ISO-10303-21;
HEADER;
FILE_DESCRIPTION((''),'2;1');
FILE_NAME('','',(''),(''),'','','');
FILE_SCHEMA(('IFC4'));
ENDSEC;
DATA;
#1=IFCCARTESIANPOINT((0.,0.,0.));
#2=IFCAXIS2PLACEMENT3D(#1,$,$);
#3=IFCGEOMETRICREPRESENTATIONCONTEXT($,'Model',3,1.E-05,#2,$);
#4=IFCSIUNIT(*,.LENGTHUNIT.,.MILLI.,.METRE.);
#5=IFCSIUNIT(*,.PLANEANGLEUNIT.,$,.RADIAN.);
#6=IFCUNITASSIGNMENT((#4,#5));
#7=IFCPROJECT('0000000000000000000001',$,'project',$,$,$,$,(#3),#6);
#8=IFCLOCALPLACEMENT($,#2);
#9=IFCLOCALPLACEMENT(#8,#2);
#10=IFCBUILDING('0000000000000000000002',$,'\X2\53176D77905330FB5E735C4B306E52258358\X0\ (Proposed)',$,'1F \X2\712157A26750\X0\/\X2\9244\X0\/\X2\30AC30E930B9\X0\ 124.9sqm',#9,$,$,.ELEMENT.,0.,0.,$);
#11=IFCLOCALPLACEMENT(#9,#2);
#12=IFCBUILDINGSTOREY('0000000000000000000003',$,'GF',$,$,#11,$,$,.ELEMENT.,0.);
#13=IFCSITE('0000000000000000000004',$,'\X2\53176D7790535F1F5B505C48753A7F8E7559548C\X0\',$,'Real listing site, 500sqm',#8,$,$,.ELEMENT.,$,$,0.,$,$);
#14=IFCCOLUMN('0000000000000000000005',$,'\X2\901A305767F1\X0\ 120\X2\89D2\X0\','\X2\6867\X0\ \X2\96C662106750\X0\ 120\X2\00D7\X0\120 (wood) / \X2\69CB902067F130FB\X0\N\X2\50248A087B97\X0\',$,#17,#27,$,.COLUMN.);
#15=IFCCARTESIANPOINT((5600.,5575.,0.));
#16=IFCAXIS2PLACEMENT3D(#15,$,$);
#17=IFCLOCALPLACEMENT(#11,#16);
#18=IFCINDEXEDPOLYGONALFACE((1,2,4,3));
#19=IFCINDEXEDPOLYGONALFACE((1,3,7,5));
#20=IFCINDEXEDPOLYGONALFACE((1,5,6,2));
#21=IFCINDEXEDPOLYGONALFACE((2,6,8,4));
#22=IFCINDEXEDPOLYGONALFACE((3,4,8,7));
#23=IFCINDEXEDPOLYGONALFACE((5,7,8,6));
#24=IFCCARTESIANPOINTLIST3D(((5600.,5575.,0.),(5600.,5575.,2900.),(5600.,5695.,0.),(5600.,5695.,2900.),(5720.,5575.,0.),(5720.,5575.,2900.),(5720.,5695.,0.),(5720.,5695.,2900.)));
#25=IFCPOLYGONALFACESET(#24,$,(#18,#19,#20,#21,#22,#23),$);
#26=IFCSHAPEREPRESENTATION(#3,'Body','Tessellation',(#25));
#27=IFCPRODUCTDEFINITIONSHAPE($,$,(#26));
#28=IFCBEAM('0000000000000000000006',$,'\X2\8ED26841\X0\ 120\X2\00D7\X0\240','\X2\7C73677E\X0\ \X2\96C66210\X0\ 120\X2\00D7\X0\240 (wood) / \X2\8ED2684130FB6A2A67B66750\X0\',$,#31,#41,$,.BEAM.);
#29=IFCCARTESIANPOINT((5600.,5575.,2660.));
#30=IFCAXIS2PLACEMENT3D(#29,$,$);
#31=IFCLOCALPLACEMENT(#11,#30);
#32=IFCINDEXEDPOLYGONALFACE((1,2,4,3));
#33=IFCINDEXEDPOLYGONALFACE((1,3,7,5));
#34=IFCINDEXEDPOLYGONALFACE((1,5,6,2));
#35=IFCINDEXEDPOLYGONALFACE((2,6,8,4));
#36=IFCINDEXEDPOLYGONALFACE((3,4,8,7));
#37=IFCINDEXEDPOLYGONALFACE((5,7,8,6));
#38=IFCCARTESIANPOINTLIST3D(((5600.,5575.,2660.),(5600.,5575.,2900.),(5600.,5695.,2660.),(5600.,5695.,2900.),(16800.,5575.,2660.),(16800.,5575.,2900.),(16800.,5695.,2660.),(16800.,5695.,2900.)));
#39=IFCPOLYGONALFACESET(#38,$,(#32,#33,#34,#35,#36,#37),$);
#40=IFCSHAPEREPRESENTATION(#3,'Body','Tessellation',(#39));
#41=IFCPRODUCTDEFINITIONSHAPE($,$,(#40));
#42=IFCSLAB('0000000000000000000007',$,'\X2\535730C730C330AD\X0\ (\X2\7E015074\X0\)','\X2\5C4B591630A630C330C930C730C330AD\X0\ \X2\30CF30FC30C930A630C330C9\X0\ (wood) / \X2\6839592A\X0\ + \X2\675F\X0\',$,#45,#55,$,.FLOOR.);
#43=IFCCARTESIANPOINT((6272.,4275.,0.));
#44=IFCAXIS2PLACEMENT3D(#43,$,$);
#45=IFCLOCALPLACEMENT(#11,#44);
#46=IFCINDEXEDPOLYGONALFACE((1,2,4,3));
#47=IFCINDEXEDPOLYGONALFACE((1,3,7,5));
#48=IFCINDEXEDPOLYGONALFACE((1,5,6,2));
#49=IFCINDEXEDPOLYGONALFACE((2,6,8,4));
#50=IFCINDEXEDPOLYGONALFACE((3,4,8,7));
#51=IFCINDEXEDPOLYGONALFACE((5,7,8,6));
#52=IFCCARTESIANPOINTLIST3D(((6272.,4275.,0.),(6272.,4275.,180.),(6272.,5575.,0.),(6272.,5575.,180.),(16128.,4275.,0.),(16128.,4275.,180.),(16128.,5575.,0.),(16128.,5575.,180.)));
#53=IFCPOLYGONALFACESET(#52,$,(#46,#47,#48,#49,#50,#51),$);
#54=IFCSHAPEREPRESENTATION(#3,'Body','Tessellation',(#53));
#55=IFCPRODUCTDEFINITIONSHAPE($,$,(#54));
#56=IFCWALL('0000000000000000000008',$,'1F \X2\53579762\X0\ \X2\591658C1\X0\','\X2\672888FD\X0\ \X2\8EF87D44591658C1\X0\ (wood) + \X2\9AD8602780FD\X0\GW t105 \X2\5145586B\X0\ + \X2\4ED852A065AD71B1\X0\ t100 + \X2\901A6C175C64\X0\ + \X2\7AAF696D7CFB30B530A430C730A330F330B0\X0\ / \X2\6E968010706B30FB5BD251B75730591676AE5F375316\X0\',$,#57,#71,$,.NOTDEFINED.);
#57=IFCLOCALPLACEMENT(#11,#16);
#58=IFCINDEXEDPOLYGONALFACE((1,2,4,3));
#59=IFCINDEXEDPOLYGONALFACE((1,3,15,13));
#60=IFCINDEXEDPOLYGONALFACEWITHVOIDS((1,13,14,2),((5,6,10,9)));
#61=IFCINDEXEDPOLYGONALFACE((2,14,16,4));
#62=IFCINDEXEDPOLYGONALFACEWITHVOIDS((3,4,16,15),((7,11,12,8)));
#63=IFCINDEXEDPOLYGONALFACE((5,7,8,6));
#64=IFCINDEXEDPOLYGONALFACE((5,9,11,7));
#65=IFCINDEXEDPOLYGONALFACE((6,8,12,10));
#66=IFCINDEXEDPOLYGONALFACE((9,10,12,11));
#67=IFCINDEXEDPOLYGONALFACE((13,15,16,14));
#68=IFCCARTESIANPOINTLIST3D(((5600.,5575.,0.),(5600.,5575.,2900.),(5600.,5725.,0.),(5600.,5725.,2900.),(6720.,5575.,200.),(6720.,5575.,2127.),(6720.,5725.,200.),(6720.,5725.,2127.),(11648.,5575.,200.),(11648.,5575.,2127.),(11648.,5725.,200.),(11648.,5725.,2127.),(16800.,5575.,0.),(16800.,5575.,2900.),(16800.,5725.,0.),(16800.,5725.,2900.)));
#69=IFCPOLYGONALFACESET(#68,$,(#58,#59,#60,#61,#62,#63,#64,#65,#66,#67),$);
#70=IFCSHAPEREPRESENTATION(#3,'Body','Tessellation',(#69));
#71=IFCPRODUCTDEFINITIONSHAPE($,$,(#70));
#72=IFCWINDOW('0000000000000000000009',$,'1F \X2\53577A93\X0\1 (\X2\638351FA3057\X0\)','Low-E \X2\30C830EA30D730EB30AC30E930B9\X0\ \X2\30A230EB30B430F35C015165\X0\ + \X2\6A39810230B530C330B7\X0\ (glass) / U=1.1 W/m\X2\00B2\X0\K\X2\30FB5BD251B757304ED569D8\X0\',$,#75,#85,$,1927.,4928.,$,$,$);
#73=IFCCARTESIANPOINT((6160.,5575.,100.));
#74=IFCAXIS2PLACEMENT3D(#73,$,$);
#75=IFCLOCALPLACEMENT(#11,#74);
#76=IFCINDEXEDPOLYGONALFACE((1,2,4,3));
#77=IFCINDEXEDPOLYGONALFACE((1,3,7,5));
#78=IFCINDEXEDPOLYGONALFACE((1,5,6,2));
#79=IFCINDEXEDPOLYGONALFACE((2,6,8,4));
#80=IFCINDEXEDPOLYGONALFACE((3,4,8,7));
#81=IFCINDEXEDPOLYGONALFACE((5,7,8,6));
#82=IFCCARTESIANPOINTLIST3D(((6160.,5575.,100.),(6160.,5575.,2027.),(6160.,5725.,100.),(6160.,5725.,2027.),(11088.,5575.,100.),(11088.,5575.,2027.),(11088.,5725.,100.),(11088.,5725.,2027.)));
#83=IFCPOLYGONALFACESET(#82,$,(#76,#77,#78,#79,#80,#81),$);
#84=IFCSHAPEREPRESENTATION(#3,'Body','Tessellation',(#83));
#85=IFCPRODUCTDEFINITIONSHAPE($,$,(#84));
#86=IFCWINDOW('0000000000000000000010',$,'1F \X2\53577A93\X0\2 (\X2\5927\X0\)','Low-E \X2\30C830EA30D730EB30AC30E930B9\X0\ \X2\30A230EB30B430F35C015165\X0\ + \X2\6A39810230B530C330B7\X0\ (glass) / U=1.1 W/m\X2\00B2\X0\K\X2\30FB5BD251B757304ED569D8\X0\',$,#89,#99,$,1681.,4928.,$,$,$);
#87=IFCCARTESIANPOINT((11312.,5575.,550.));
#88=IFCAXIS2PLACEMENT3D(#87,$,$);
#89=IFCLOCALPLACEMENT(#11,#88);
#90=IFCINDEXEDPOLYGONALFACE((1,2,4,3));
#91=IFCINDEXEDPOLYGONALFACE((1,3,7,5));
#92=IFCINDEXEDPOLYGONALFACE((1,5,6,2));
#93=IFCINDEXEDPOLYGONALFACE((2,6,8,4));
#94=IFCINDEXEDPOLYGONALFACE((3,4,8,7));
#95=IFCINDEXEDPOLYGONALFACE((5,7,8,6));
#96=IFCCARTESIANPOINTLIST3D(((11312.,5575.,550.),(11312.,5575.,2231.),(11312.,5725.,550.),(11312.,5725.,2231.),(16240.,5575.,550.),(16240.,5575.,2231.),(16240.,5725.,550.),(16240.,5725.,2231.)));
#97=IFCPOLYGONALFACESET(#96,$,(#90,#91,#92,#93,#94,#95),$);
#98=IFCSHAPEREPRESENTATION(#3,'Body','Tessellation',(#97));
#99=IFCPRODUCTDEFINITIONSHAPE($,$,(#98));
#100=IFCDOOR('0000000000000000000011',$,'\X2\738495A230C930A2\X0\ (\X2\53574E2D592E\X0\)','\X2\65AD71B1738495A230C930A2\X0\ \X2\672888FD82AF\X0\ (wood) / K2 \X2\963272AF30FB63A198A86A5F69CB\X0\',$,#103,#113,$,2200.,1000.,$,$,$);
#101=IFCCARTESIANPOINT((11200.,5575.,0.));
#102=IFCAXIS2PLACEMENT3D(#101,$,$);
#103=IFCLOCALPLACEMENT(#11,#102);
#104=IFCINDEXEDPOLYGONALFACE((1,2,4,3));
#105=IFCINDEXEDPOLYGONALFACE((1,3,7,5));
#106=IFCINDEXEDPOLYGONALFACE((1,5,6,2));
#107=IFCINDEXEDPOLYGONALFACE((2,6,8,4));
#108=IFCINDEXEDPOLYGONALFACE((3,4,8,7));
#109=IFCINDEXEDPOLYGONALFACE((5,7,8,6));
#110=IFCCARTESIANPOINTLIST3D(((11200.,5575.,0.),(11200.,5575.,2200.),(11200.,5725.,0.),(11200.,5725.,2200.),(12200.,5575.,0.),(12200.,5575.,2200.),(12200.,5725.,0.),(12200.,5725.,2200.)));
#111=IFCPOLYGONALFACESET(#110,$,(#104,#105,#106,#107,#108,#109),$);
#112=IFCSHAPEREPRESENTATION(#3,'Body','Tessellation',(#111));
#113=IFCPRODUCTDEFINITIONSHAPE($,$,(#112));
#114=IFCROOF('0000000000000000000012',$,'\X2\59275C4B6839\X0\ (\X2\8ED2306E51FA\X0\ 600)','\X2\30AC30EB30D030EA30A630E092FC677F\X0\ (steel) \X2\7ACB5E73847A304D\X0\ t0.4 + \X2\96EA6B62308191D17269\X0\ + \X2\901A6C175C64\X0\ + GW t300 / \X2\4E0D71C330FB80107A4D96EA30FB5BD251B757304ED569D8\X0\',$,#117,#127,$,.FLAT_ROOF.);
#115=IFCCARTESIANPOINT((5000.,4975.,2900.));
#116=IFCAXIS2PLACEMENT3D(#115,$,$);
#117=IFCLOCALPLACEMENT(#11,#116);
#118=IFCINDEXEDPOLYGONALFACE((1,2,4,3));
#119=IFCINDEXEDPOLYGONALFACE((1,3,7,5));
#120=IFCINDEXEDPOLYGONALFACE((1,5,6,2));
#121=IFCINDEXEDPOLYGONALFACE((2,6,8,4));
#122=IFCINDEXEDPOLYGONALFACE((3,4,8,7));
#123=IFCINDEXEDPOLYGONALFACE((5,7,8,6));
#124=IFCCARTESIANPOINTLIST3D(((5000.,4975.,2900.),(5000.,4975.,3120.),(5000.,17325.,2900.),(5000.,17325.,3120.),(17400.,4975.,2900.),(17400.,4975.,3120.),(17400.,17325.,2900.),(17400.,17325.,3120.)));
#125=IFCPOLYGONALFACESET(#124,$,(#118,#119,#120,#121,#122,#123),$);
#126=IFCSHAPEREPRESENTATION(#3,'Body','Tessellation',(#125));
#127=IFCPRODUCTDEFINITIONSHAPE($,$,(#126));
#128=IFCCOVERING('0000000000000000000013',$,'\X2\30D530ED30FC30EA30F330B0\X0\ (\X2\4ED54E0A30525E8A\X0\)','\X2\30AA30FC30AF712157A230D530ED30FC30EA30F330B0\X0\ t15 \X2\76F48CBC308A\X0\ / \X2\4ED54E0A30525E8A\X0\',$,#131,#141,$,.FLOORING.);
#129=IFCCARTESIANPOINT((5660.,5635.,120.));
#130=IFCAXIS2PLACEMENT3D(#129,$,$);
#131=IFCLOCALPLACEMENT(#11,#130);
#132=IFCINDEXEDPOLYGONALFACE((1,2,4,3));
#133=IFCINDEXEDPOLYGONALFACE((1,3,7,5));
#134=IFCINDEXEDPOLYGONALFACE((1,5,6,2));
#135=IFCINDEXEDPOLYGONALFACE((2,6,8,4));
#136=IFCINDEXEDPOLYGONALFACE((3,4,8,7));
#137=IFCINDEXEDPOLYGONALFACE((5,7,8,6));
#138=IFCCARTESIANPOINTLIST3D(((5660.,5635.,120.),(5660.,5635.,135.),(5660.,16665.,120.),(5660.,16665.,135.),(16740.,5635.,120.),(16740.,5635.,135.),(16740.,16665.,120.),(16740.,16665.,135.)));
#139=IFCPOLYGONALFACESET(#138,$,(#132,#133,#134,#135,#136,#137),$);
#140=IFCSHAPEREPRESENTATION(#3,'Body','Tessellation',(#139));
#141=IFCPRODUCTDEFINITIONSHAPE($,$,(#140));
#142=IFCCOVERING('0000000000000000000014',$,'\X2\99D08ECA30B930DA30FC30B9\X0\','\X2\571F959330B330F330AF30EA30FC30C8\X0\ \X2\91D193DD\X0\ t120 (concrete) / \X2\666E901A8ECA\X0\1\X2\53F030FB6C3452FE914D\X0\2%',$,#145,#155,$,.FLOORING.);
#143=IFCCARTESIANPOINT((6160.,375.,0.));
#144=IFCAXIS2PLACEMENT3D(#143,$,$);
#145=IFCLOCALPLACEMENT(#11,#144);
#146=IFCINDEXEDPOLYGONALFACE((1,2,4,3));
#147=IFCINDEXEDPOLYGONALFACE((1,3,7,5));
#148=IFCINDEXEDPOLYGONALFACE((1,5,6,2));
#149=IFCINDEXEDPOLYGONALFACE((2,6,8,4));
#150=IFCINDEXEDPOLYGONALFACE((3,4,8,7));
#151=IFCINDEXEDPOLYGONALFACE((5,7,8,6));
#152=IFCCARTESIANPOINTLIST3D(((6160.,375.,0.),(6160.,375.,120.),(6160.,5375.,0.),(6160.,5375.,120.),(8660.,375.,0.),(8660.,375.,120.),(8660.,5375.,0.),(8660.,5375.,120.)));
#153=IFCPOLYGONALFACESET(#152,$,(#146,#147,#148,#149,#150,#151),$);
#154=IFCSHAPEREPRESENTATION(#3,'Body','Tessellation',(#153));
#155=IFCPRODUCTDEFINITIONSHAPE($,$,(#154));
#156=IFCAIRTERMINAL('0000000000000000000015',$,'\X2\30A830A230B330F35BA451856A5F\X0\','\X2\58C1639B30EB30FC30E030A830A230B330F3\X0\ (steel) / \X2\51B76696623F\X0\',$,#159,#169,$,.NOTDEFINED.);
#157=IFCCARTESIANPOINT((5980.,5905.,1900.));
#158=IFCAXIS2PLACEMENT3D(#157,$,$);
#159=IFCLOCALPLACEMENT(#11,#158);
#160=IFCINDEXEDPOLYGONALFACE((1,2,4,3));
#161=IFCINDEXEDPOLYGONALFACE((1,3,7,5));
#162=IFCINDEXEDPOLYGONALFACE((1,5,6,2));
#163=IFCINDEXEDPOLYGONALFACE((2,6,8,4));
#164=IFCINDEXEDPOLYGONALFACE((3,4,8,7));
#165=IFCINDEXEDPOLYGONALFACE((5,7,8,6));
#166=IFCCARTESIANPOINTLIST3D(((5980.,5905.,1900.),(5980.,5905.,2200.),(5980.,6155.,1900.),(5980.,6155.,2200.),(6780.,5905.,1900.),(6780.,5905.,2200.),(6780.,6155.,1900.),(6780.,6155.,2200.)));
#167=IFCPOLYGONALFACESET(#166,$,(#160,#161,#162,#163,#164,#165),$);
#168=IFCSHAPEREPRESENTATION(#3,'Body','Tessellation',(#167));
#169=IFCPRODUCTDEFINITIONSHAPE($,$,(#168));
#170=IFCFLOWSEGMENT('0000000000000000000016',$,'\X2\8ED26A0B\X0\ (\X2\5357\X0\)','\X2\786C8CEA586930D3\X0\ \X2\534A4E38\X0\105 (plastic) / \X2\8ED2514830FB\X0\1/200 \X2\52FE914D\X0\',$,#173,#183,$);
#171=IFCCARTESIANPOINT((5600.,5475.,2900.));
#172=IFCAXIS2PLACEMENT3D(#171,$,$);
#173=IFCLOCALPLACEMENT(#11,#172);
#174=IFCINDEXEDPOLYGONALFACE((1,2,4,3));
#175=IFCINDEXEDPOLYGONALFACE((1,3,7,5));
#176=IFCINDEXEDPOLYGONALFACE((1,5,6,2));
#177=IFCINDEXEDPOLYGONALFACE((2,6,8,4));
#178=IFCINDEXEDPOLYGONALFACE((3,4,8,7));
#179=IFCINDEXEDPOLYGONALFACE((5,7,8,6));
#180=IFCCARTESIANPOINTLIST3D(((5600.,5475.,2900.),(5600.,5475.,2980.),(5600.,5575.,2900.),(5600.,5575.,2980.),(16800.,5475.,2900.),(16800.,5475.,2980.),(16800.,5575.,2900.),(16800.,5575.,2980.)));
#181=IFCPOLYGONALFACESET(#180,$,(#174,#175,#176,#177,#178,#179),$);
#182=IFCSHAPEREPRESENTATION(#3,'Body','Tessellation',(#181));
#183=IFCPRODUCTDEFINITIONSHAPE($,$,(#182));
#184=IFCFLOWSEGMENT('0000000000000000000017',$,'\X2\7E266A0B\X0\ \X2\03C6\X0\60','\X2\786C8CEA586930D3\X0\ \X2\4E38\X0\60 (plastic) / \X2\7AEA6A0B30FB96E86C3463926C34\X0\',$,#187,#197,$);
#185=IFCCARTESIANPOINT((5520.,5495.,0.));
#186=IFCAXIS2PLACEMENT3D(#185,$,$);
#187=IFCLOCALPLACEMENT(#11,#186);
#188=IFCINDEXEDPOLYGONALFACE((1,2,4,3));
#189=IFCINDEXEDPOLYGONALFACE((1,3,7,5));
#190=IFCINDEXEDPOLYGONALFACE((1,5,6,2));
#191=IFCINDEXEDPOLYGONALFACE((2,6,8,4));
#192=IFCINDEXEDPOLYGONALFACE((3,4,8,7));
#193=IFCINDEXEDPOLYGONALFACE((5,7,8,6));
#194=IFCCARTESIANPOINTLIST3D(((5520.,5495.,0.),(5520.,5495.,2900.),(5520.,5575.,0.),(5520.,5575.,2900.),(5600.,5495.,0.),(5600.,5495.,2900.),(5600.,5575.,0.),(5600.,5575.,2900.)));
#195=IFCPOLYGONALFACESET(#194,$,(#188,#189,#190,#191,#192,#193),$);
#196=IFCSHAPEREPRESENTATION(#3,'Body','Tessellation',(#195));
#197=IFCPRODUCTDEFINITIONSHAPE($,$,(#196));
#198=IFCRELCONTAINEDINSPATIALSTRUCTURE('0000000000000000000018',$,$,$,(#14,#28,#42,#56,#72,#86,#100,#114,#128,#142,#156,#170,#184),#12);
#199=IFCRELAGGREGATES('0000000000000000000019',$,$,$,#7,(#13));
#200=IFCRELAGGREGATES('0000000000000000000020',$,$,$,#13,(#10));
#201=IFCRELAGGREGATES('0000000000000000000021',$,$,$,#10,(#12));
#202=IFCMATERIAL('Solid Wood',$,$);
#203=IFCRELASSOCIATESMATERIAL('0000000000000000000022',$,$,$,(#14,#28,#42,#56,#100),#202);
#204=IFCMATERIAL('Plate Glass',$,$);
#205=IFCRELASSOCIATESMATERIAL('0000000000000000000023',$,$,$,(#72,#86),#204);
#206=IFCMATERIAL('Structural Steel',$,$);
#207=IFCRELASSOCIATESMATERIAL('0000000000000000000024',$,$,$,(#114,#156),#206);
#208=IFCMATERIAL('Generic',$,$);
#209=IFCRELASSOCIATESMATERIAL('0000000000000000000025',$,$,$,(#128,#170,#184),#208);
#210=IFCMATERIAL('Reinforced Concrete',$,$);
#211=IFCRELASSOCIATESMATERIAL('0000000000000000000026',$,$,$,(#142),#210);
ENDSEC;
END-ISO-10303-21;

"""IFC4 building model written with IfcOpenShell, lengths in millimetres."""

from ifc_helpers import new_model, si_unit, frame, frame_2d, origin, place, context, project, spatial, rectangle, extrude, material, element, fill, save


model = new_model("IFC4")

# Units and contexts
model_context = context("Model", 3, precision=1e-05, world=origin())
ifc_project = project(units=[si_unit("LENGTHUNIT", "METRE", prefix="MILLI"), si_unit("PLANEANGLEUNIT", "RADIAN")], contexts=[model_context])

# Site, building, storey
site_placement = place(None, origin())
site = spatial("IfcSite", under=ifc_project, at=site_placement, Name="北海道弟子屈町美留和", ObjectType="Real listing site, 500sqm", CompositionType="ELEMENT", RefElevation=0.0)
building_placement = place(site_placement, origin())
building = spatial("IfcBuilding", under=site, at=building_placement, Name="北海道・平屋の別荘 (Proposed)", ObjectType="1F 無垢材/鉄/ガラス 124.9sqm", CompositionType="ELEMENT", ElevationOfRefHeight=0.0, ElevationOfTerrain=0.0)
storey_placement = place(building_placement, origin())
storey = spatial("IfcBuildingStorey", under=building, at=storey_placement, Name="GF", CompositionType="ELEMENT", Elevation=0.0)

# Column
ifc_material_1 = material(Name="Solid Wood")
column_1_placement = place(storey_placement, frame((5600.0, 5575.0, 0.0)))
element("IfcColumn", 1, at=column_1_placement, inside=storey, material=ifc_material_1, Name="通し柱 120角", Description="桧 集成材 120×120 (wood) / 構造柱・N値計算", PredefinedType="COLUMN", context=model_context, shape_type="SweptSolid", body=[
    extrude(rectangle(XDim=120.0, YDim=120.0, at=frame_2d((60.0, 60.0))), frame((5600.0, 5575.0, 0.0)), (0.0, 0.0, 1.0), 2900.0),
])

# Beam
beam_1_placement = place(storey_placement, frame((5600.0, 5575.0, 2660.0)))
element("IfcBeam", 2, at=beam_1_placement, inside=storey, material=ifc_material_1, Name="軒桁 120×240", Description="米松 集成 120×240 (wood) / 軒桁・横架材", PredefinedType="BEAM", context=model_context, shape_type="SweptSolid", body=[
    extrude(rectangle(XDim=11200.0, YDim=120.0, at=frame_2d((5600.0, 60.0))), frame((5600.0, 5575.0, 2660.0)), (0.0, 0.0, 1.0), 240.0),
])

# Slab
ifc_material_2 = material(Name="Reinforced Concrete")
slab_1_placement = place(storey_placement, frame((6272.0, 4275.0, 0.0)))
element("IfcSlab", 3, at=slab_1_placement, inside=storey, material=ifc_material_1, Name="南デッキ (縁側)", Description="屋外ウッドデッキ ハードウッド (wood) / 根太 + 束", PredefinedType="FLOOR", context=model_context, shape_type="SweptSolid", body=[
    extrude(rectangle(XDim=9856.0, YDim=1300.0, at=frame_2d((4928.0, 650.0))), frame((6272.0, 4275.0, 0.0)), (0.0, 0.0, 1.0), 180.0),
])

# Wall, openings, windows, door
wall_1_placement = place(storey_placement, frame((5600.0, 5575.0, 0.0)))
wall_1 = element("IfcWall", 4, at=wall_1_placement, inside=storey, material=ifc_material_1, Name="1F 南面 外壁", Description="木製 軸組外壁 (wood) + 高性能GW t105 充填 + 付加断熱 t100 + 通気層 + 窯業系サイディング / 準耐火・寒冷地外皮強化", PredefinedType="NOTDEFINED", context=model_context, shape_type="SweptSolid", body=[
    extrude(rectangle(XDim=11200.0, YDim=150.0, at=frame_2d((5600.0, 75.0))), frame((5600.0, 5575.0, 0.0)), (0.0, 0.0, 1.0), 2900.0),
])
opening_1_placement = place(storey_placement, frame((6160.0, 5575.0, 100.0)))
opening_1 = element("IfcOpeningElement", 5, at=opening_1_placement, cuts=wall_1, PredefinedType="NOTDEFINED", context=model_context, shape_type="SweptSolid", body=[
    extrude(rectangle(XDim=4928.0, YDim=150.0, at=frame_2d((2464.0, 75.0))), frame((6160.0, 5575.0, 100.0)), (0.0, 0.0, 1.0), 1927.0),
])
opening_2_placement = place(storey_placement, frame((11312.0, 5575.0, 550.0)))
opening_2 = element("IfcOpeningElement", 6, at=opening_2_placement, cuts=wall_1, PredefinedType="NOTDEFINED", context=model_context, shape_type="SweptSolid", body=[
    extrude(rectangle(XDim=4928.0, YDim=150.0, at=frame_2d((2464.0, 75.0))), frame((11312.0, 5575.0, 550.0)), (0.0, 0.0, 1.0), 1681.0),
])
opening_3_placement = place(storey_placement, frame((11200.0, 5575.0, 0.0)))
opening_3 = element("IfcOpeningElement", 7, at=opening_3_placement, cuts=wall_1, PredefinedType="NOTDEFINED", context=model_context, shape_type="SweptSolid", body=[
    extrude(rectangle(XDim=1000.0, YDim=150.0, at=frame_2d((500.0, 75.0))), frame((11200.0, 5575.0, 0.0)), (0.0, 0.0, 1.0), 2200.0),
])
ifc_material_3 = material(Name="Plate Glass")
window_1_placement = place(storey_placement, frame((6160.0, 5575.0, 100.0)))
window_1 = element("IfcWindow", 8, at=window_1_placement, inside=storey, material=ifc_material_3, Name="1F 南窓1 (掃出し)", Description="Low-E トリプルガラス アルゴン封入 + 樹脂サッシ (glass) / U=1.1 W/m²K・寒冷地仕様", OverallHeight=1927.0, OverallWidth=4928.0, context=model_context, shape_type="SweptSolid", body=[
    extrude(rectangle(XDim=4928.0, YDim=150.0, at=frame_2d((2464.0, 75.0))), frame((6160.0, 5575.0, 100.0)), (0.0, 0.0, 1.0), 1927.0),
])
fill(opening_1, window_1)
window_2_placement = place(storey_placement, frame((11312.0, 5575.0, 550.0)))
window_2 = element("IfcWindow", 9, at=window_2_placement, inside=storey, material=ifc_material_3, Name="1F 南窓2 (大)", Description="Low-E トリプルガラス アルゴン封入 + 樹脂サッシ (glass) / U=1.1 W/m²K・寒冷地仕様", OverallHeight=1681.0, OverallWidth=4928.0, context=model_context, shape_type="SweptSolid", body=[
    extrude(rectangle(XDim=4928.0, YDim=150.0, at=frame_2d((2464.0, 75.0))), frame((11312.0, 5575.0, 550.0)), (0.0, 0.0, 1.0), 1681.0),
])
fill(opening_2, window_2)
door_placement = place(storey_placement, frame((11200.0, 5575.0, 0.0)))
door = element("IfcDoor", 10, at=door_placement, inside=storey, material=ifc_material_1, Name="玄関ドア (南中央)", Description="断熱玄関ドア 木製芯 (wood) / K2 防犯・採風機構", OverallHeight=2200.0, OverallWidth=1000.0, context=model_context, shape_type="SweptSolid", body=[
    extrude(rectangle(XDim=1000.0, YDim=150.0, at=frame_2d((500.0, 75.0))), frame((11200.0, 5575.0, 0.0)), (0.0, 0.0, 1.0), 2200.0),
])
fill(opening_3, door)

# Roof
ifc_material_4 = material(Name="Structural Steel")
roof_placement = place(storey_placement, frame((5000.0, 4975.0, 2900.0)))
element("IfcRoof", 11, at=roof_placement, inside=storey, material=ifc_material_4, Name="大屋根 (軒の出 600)", Description="ガルバリウム鋼板 (steel) 立平葺き t0.4 + 雪止め金物 + 通気層 + GW t300 / 不燃・耐積雪・寒冷地仕様", PredefinedType="FLAT_ROOF", context=model_context, shape_type="SweptSolid", body=[
    extrude(rectangle(XDim=12400.0, YDim=12350.0, at=frame_2d((6200.0, 6175.0))), frame((5000.0, 4975.0, 2900.0)), (0.0, 0.0, 1.0), 220.0),
])

# Coverings
ifc_material_5 = material(Name="Generic")
covering_1_placement = place(storey_placement, frame((5660.0, 5635.0, 120.0)))
element("IfcCovering", 12, at=covering_1_placement, inside=storey, material=ifc_material_5, Name="フローリング (仕上げ床)", Description="オーク無垢フローリング t15 直貼り / 仕上げ床", PredefinedType="FLOORING", context=model_context, shape_type="SweptSolid", body=[
    extrude(rectangle(XDim=11080.0, YDim=11030.0, at=frame_2d((5540.0, 5515.0))), frame((5660.0, 5635.0, 120.0)), (0.0, 0.0, 1.0), 15.0),
])
covering_2_placement = place(storey_placement, frame((6160.0, 375.0, 0.0)))
element("IfcCovering", 13, at=covering_2_placement, inside=storey, material=ifc_material_2, Name="駐車スペース", Description="土間コンクリート 金鏝 t120 (concrete) / 普通車1台・水勾配2%", PredefinedType="FLOORING", context=model_context, shape_type="SweptSolid", body=[
    extrude(rectangle(XDim=2500.0, YDim=5000.0, at=frame_2d((1250.0, 2500.0))), frame((6160.0, 375.0, 0.0)), (0.0, 0.0, 1.0), 120.0),
])

# Air terminal
air_terminal_placement = place(storey_placement, frame((5980.0, 5905.0, 1900.0)))
element("IfcAirTerminal", 14, at=air_terminal_placement, inside=storey, material=ifc_material_4, Name="エアコン室内機", Description="壁掛ルームエアコン (steel) / 冷暖房", PredefinedType="NOTDEFINED", context=model_context, shape_type="SweptSolid", body=[
    extrude(rectangle(XDim=800.0, YDim=250.0, at=frame_2d((400.0, 125.0))), frame((5980.0, 5905.0, 1900.0)), (0.0, 0.0, 1.0), 300.0),
])

# Flow segments
flow_segment_1_placement = place(storey_placement, frame((5600.0, 5475.0, 2900.0)))
element("IfcFlowSegment", 15, at=flow_segment_1_placement, inside=storey, material=ifc_material_5, Name="軒樋 (南)", Description="硬質塩ビ 半丸105 (plastic) / 軒先・1/200 勾配", context=model_context, shape_type="SweptSolid", body=[
    extrude(rectangle(XDim=11200.0, YDim=100.0, at=frame_2d((5600.0, 50.0))), frame((5600.0, 5475.0, 2900.0)), (0.0, 0.0, 1.0), 80.0),
])
flow_segment_2_placement = place(storey_placement, frame((5520.0, 5495.0, 0.0)))
element("IfcFlowSegment", 16, at=flow_segment_2_placement, inside=storey, material=ifc_material_5, Name="縦樋 φ60", Description="硬質塩ビ 丸60 (plastic) / 竪樋・雨水排水", context=model_context, shape_type="SweptSolid", body=[
    extrude(rectangle(XDim=80.0, YDim=80.0, at=frame_2d((40.0, 40.0))), frame((5520.0, 5495.0, 0.0)), (0.0, 0.0, 1.0), 2900.0),
])

save(model, "model.ifc")
